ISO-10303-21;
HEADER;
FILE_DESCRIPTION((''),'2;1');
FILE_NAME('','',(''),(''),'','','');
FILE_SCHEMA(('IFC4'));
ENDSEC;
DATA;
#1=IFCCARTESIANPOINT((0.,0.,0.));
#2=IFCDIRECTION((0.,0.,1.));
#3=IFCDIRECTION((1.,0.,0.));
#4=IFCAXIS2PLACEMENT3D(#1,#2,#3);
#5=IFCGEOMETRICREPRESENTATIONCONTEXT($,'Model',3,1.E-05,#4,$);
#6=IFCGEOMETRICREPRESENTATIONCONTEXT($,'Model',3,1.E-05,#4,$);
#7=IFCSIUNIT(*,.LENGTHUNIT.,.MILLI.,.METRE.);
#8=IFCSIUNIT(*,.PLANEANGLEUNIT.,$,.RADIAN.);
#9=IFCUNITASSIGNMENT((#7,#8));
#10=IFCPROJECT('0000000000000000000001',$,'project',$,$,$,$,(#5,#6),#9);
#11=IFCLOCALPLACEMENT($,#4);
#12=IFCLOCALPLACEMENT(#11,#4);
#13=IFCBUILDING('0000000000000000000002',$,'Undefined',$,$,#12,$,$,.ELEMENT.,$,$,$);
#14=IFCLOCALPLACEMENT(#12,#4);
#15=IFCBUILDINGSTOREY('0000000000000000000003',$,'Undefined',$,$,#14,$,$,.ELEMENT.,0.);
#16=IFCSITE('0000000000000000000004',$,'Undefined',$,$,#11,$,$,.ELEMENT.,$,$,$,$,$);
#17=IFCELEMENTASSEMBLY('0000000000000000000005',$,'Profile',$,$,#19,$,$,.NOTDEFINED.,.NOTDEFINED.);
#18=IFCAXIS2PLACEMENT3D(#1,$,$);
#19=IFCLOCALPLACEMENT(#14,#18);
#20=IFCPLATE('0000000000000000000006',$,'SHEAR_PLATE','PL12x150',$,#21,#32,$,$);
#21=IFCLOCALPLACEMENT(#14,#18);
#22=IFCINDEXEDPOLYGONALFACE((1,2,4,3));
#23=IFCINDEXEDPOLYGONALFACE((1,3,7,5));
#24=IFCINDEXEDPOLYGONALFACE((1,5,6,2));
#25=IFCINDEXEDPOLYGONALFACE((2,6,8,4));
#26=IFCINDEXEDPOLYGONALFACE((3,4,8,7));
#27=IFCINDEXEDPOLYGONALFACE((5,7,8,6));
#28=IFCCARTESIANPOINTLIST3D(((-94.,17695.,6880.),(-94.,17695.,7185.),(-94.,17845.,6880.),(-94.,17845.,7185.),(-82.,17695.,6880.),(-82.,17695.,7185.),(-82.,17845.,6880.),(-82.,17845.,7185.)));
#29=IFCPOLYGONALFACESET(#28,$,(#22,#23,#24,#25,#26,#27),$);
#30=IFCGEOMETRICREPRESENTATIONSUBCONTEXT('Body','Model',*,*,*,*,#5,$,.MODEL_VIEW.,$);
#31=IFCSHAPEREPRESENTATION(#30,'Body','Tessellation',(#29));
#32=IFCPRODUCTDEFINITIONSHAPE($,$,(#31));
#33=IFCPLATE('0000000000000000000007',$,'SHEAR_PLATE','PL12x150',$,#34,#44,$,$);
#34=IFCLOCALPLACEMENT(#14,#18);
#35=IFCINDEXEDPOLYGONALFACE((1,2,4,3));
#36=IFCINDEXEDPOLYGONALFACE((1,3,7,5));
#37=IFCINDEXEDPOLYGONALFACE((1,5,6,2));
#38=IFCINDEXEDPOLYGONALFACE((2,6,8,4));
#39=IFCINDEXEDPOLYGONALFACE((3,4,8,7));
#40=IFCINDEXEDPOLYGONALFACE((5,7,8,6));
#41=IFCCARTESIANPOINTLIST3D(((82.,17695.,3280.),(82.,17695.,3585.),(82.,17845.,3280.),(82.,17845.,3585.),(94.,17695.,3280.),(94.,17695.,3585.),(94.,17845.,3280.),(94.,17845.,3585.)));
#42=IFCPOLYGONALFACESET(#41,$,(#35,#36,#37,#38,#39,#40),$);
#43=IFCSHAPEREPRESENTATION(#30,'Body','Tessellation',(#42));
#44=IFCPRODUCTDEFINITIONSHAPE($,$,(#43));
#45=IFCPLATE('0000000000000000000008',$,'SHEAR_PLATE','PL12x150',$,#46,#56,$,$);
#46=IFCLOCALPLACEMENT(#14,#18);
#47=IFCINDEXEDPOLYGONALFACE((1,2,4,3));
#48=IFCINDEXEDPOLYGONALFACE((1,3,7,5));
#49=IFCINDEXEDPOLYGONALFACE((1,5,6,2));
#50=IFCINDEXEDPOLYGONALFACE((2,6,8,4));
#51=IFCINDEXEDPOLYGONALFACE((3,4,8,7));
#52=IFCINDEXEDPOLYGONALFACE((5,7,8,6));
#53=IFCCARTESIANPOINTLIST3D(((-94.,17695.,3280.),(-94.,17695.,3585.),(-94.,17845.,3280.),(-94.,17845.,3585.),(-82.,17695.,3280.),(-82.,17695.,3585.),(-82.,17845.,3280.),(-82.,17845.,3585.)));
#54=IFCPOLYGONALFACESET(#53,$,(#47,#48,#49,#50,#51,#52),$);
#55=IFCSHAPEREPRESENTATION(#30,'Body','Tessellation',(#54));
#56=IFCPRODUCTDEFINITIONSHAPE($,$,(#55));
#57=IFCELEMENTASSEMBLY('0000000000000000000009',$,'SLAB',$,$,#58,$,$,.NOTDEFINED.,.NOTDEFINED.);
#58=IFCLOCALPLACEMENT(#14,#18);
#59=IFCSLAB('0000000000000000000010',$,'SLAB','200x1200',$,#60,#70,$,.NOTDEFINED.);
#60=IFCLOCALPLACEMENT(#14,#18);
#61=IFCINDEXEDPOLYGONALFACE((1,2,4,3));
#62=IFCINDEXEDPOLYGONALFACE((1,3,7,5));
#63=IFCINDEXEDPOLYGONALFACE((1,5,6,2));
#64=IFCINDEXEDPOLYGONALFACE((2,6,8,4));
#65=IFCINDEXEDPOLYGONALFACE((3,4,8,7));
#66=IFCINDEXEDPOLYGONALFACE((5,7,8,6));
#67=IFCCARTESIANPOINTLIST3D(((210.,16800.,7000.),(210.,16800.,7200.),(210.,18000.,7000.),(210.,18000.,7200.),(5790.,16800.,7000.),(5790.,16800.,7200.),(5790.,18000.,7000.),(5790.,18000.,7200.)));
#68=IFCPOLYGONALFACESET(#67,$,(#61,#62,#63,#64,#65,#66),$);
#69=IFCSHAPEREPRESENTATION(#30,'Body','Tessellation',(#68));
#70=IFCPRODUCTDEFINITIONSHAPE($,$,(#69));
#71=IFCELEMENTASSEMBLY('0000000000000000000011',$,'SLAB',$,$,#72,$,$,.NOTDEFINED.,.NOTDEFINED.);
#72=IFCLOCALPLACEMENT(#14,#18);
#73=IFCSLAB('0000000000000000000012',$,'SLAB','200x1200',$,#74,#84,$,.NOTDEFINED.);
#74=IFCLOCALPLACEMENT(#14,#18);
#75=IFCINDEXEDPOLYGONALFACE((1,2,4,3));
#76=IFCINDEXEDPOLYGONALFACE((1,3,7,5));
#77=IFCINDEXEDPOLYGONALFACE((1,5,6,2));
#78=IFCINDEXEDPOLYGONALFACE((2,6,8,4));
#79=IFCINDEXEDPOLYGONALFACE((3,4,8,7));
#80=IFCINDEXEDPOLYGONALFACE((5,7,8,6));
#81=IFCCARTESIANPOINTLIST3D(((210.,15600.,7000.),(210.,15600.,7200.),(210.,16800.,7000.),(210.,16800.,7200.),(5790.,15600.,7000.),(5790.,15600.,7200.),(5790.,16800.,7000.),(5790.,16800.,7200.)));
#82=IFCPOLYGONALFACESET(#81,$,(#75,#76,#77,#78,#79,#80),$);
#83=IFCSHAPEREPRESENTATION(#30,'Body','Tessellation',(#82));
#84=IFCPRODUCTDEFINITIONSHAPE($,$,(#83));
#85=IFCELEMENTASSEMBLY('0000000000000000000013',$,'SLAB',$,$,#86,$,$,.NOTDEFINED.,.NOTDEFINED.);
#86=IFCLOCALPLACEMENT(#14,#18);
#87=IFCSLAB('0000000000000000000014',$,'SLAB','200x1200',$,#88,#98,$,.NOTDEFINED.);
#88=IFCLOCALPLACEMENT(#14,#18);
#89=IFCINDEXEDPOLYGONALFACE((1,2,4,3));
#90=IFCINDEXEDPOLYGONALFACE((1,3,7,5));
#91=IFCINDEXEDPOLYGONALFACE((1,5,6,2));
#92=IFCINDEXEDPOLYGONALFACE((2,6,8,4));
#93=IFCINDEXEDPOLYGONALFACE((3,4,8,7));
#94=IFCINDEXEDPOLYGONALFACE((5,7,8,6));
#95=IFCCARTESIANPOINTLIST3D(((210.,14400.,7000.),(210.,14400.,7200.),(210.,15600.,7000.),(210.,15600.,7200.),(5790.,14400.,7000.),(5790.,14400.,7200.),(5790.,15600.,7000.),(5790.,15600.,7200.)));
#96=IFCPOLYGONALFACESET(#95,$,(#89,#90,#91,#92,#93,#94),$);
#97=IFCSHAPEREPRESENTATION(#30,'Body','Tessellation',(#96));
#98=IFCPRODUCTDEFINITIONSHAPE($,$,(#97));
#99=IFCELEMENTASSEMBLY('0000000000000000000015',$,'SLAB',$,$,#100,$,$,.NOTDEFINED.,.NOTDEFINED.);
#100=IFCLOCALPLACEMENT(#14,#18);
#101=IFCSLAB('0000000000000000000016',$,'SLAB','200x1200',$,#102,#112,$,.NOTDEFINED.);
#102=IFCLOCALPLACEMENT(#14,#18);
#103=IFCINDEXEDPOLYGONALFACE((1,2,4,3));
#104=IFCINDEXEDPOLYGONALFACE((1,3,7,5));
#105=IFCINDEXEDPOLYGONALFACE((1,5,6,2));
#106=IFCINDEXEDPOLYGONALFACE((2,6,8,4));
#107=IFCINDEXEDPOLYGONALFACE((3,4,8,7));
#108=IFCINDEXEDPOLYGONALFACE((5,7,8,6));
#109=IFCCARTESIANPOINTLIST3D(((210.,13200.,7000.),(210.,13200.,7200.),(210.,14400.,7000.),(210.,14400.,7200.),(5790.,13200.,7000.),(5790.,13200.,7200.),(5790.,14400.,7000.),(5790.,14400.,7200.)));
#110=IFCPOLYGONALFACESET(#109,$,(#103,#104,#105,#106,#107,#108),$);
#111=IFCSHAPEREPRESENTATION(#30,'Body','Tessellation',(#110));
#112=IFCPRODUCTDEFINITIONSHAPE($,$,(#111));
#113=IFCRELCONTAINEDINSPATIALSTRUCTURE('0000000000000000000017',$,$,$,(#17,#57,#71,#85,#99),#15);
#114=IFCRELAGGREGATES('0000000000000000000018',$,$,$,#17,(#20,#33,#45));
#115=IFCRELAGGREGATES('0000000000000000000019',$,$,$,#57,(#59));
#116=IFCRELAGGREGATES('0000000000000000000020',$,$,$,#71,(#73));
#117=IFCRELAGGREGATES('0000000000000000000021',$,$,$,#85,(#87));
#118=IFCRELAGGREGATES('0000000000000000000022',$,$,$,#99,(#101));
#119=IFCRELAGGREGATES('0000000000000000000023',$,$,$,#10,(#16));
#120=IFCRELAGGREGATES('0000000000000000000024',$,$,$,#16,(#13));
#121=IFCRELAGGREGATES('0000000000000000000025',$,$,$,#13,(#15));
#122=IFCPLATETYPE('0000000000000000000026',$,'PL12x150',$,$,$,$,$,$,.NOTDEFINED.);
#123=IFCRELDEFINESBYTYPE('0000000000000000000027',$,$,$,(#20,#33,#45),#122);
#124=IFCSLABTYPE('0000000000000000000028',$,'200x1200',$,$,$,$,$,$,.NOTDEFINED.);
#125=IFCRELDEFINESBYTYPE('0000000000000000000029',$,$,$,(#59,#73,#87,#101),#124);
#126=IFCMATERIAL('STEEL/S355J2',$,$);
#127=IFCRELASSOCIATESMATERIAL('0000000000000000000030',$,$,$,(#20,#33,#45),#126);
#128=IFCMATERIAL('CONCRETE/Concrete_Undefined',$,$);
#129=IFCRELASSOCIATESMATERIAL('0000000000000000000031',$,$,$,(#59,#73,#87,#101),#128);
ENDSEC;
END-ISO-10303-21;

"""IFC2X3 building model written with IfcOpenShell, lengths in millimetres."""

from ifc_helpers import new_model, si_unit, frame, origin_with_axes, place, context, subcontext, project, spatial, polyline, outline, extrude, material, type_object, element, aggregate, save


model = new_model("IFC2X3")

# Units and contexts
model_context_1 = context("Model", 3, precision=1e-05, world=origin_with_axes())
model_context_2 = context("Model", 3, precision=1e-05, world=origin_with_axes())
body_context = subcontext(model_context_1, "Body", "Model", "MODEL_VIEW")
ifc_project = project(units=[si_unit("LENGTHUNIT", "METRE", prefix="MILLI"), si_unit("PLANEANGLEUNIT", "RADIAN")], contexts=[model_context_1, model_context_2])

# Site, building, storey
site_placement = place(None, origin_with_axes())
site = spatial("IfcSite", under=ifc_project, at=site_placement, Name="Undefined", CompositionType="ELEMENT")
building_placement = place(site_placement, origin_with_axes())
building = spatial("IfcBuilding", under=site, at=building_placement, Name="Undefined", CompositionType="ELEMENT")
storey_placement = place(building_placement, origin_with_axes())
storey = spatial("IfcBuildingStorey", under=building, at=storey_placement, Name="Undefined", CompositionType="ELEMENT", Elevation=0.0)

# Element assembly
ifc_material_1 = material(Name="STEEL/S355J2")
assembly_1_placement = place(storey_placement, origin_with_axes())
assembly_1 = element("IfcElementAssembly", 1, at=assembly_1_placement, inside=storey, Name="Profile", AssemblyPlace="NOTDEFINED", PredefinedType="NOTDEFINED")

# Plates
plate_type_1 = type_object("IfcPlateType", Name="PL12x150", PredefinedType="NOTDEFINED")
plate_1_placement = place(assembly_1_placement, frame((-88.0, 17845.0, 7185.0), z_axis=(1.0, 0.0, 0.0), x_axis=(0.0, -1.0, 0.0)))
plate_1 = element("IfcPlate", 2, at=plate_1_placement, type_object=plate_type_1, material=ifc_material_1, Name="SHEAR_PLATE", Description="PL12x150", context=body_context, shape_type="SweptSolid", body=[
    extrude(outline(polyline([(0.0, 0.0), (150.0, 0.0), (150.0, 0.0), (150.0, 305.0), (150.0, 305.0), (0.0, 305.0), (0.0, 305.0), (0.0, 0.0)])), frame((0.0, 0.0, -6.0), z_axis=(0.0, 0.0, 1.0), x_axis=(1.0, 0.0, 0.0)), (0.0, 0.0, 1.0), 12.0),
])
plate_2_placement = place(assembly_1_placement, frame((88.0, 17845.0, 3585.0), z_axis=(1.0, 0.0, 0.0), x_axis=(0.0, -1.0, 0.0)))
plate_2 = element("IfcPlate", 3, at=plate_2_placement, type_object=plate_type_1, material=ifc_material_1, Name="SHEAR_PLATE", Description="PL12x150", context=body_context, shape_type="SweptSolid", body=[
    extrude(outline(polyline([(0.0, 0.0), (150.0, 0.0), (150.0, 0.0), (150.0, 305.0), (150.0, 305.0), (0.0, 305.0), (0.0, 305.0), (0.0, 0.0)])), frame((0.0, 0.0, -6.0), z_axis=(0.0, 0.0, 1.0), x_axis=(1.0, 0.0, 0.0)), (0.0, 0.0, 1.0), 12.0),
])
plate_3_placement = place(assembly_1_placement, frame((-88.0, 17845.0, 3585.0), z_axis=(1.0, 0.0, 0.0), x_axis=(0.0, -1.0, 0.0)))
plate_3 = element("IfcPlate", 4, at=plate_3_placement, type_object=plate_type_1, material=ifc_material_1, Name="SHEAR_PLATE", Description="PL12x150", context=body_context, shape_type="SweptSolid", body=[
    extrude(outline(polyline([(0.0, 0.0), (150.0, 0.0), (150.0, 0.0), (150.0, 305.0), (150.0, 305.0), (0.0, 305.0), (0.0, 305.0), (0.0, 0.0)])), frame((0.0, 0.0, -6.0), z_axis=(0.0, 0.0, 1.0), x_axis=(1.0, 0.0, 0.0)), (0.0, 0.0, 1.0), 12.0),
])
aggregate(assembly_1, [plate_1, plate_2, plate_3])

# Element assemblies, slabs
assembly_2_placement = place(storey_placement, origin_with_axes())
assembly_2 = element("IfcElementAssembly", 5, at=assembly_2_placement, inside=storey, Name="SLAB", AssemblyPlace="NOTDEFINED", PredefinedType="NOTDEFINED")
ifc_material_2 = material(Name="CONCRETE/Concrete_Undefined")
slab_type = type_object("IfcSlabType", Name="200x1200", PredefinedType="NOTDEFINED")
slab_1_placement = place(assembly_2_placement, frame((5790.0, 16800.0, 7100.0), z_axis=(0.0, 0.0, 1.0), x_axis=(0.0, 1.0, 0.0)))
slab_1 = element("IfcSlab", 6, at=slab_1_placement, type_object=slab_type, material=ifc_material_2, Name="SLAB", Description="200x1200", PredefinedType="NOTDEFINED", context=body_context, shape_type="SweptSolid", body=[
    extrude(outline(polyline([(0.0, 0.0), (1200.0, 0.0), (1200.0, 5580.0), (0.0, 5580.0), (0.0, 0.0)])), frame((0.0, 0.0, -100.0), z_axis=(0.0, 0.0, 1.0), x_axis=(1.0, 0.0, 0.0)), (0.0, 0.0, 1.0), 200.0),
])
aggregate(assembly_2, [slab_1])
assembly_3_placement = place(storey_placement, origin_with_axes())
assembly_3 = element("IfcElementAssembly", 7, at=assembly_3_placement, inside=storey, Name="SLAB", AssemblyPlace="NOTDEFINED", PredefinedType="NOTDEFINED")
slab_2_placement = place(assembly_3_placement, frame((5790.0, 15600.0, 7100.0), z_axis=(0.0, 0.0, 1.0), x_axis=(0.0, 1.0, 0.0)))
slab_2 = element("IfcSlab", 8, at=slab_2_placement, type_object=slab_type, material=ifc_material_2, Name="SLAB", Description="200x1200", PredefinedType="NOTDEFINED", context=body_context, shape_type="SweptSolid", body=[
    extrude(outline(polyline([(0.0, 0.0), (1200.0, 0.0), (1200.0, 5580.0), (0.0, 5580.0), (0.0, 0.0)])), frame((0.0, 0.0, -100.0), z_axis=(0.0, 0.0, 1.0), x_axis=(1.0, 0.0, 0.0)), (0.0, 0.0, 1.0), 200.0),
])
aggregate(assembly_3, [slab_2])
assembly_4_placement = place(storey_placement, origin_with_axes())
assembly_4 = element("IfcElementAssembly", 9, at=assembly_4_placement, inside=storey, Name="SLAB", AssemblyPlace="NOTDEFINED", PredefinedType="NOTDEFINED")
slab_3_placement = place(assembly_4_placement, frame((5790.0, 14400.0, 7100.0), z_axis=(0.0, 0.0, 1.0), x_axis=(0.0, 1.0, 0.0)))
slab_3 = element("IfcSlab", 10, at=slab_3_placement, type_object=slab_type, material=ifc_material_2, Name="SLAB", Description="200x1200", PredefinedType="NOTDEFINED", context=body_context, shape_type="SweptSolid", body=[
    extrude(outline(polyline([(0.0, 0.0), (1200.0, 0.0), (1200.0, 5580.0), (0.0, 5580.0), (0.0, 0.0)])), frame((0.0, 0.0, -100.0), z_axis=(0.0, 0.0, 1.0), x_axis=(1.0, 0.0, 0.0)), (0.0, 0.0, 1.0), 200.0),
])
aggregate(assembly_4, [slab_3])
assembly_5_placement = place(storey_placement, origin_with_axes())
assembly_5 = element("IfcElementAssembly", 11, at=assembly_5_placement, inside=storey, Name="SLAB", AssemblyPlace="NOTDEFINED", PredefinedType="NOTDEFINED")
slab_4_placement = place(assembly_5_placement, frame((5790.0, 13200.0, 7100.0), z_axis=(0.0, 0.0, 1.0), x_axis=(0.0, 1.0, 0.0)))
slab_4 = element("IfcSlab", 12, at=slab_4_placement, type_object=slab_type, material=ifc_material_2, Name="SLAB", Description="200x1200", PredefinedType="NOTDEFINED", context=body_context, shape_type="SweptSolid", body=[
    extrude(outline(polyline([(0.0, 0.0), (1200.0, 0.0), (1200.0, 5580.0), (0.0, 5580.0), (0.0, 0.0)])), frame((0.0, 0.0, -100.0), z_axis=(0.0, 0.0, 1.0), x_axis=(1.0, 0.0, 0.0)), (0.0, 0.0, 1.0), 200.0),
])
aggregate(assembly_5, [slab_4])

save(model, "model.ifc")
